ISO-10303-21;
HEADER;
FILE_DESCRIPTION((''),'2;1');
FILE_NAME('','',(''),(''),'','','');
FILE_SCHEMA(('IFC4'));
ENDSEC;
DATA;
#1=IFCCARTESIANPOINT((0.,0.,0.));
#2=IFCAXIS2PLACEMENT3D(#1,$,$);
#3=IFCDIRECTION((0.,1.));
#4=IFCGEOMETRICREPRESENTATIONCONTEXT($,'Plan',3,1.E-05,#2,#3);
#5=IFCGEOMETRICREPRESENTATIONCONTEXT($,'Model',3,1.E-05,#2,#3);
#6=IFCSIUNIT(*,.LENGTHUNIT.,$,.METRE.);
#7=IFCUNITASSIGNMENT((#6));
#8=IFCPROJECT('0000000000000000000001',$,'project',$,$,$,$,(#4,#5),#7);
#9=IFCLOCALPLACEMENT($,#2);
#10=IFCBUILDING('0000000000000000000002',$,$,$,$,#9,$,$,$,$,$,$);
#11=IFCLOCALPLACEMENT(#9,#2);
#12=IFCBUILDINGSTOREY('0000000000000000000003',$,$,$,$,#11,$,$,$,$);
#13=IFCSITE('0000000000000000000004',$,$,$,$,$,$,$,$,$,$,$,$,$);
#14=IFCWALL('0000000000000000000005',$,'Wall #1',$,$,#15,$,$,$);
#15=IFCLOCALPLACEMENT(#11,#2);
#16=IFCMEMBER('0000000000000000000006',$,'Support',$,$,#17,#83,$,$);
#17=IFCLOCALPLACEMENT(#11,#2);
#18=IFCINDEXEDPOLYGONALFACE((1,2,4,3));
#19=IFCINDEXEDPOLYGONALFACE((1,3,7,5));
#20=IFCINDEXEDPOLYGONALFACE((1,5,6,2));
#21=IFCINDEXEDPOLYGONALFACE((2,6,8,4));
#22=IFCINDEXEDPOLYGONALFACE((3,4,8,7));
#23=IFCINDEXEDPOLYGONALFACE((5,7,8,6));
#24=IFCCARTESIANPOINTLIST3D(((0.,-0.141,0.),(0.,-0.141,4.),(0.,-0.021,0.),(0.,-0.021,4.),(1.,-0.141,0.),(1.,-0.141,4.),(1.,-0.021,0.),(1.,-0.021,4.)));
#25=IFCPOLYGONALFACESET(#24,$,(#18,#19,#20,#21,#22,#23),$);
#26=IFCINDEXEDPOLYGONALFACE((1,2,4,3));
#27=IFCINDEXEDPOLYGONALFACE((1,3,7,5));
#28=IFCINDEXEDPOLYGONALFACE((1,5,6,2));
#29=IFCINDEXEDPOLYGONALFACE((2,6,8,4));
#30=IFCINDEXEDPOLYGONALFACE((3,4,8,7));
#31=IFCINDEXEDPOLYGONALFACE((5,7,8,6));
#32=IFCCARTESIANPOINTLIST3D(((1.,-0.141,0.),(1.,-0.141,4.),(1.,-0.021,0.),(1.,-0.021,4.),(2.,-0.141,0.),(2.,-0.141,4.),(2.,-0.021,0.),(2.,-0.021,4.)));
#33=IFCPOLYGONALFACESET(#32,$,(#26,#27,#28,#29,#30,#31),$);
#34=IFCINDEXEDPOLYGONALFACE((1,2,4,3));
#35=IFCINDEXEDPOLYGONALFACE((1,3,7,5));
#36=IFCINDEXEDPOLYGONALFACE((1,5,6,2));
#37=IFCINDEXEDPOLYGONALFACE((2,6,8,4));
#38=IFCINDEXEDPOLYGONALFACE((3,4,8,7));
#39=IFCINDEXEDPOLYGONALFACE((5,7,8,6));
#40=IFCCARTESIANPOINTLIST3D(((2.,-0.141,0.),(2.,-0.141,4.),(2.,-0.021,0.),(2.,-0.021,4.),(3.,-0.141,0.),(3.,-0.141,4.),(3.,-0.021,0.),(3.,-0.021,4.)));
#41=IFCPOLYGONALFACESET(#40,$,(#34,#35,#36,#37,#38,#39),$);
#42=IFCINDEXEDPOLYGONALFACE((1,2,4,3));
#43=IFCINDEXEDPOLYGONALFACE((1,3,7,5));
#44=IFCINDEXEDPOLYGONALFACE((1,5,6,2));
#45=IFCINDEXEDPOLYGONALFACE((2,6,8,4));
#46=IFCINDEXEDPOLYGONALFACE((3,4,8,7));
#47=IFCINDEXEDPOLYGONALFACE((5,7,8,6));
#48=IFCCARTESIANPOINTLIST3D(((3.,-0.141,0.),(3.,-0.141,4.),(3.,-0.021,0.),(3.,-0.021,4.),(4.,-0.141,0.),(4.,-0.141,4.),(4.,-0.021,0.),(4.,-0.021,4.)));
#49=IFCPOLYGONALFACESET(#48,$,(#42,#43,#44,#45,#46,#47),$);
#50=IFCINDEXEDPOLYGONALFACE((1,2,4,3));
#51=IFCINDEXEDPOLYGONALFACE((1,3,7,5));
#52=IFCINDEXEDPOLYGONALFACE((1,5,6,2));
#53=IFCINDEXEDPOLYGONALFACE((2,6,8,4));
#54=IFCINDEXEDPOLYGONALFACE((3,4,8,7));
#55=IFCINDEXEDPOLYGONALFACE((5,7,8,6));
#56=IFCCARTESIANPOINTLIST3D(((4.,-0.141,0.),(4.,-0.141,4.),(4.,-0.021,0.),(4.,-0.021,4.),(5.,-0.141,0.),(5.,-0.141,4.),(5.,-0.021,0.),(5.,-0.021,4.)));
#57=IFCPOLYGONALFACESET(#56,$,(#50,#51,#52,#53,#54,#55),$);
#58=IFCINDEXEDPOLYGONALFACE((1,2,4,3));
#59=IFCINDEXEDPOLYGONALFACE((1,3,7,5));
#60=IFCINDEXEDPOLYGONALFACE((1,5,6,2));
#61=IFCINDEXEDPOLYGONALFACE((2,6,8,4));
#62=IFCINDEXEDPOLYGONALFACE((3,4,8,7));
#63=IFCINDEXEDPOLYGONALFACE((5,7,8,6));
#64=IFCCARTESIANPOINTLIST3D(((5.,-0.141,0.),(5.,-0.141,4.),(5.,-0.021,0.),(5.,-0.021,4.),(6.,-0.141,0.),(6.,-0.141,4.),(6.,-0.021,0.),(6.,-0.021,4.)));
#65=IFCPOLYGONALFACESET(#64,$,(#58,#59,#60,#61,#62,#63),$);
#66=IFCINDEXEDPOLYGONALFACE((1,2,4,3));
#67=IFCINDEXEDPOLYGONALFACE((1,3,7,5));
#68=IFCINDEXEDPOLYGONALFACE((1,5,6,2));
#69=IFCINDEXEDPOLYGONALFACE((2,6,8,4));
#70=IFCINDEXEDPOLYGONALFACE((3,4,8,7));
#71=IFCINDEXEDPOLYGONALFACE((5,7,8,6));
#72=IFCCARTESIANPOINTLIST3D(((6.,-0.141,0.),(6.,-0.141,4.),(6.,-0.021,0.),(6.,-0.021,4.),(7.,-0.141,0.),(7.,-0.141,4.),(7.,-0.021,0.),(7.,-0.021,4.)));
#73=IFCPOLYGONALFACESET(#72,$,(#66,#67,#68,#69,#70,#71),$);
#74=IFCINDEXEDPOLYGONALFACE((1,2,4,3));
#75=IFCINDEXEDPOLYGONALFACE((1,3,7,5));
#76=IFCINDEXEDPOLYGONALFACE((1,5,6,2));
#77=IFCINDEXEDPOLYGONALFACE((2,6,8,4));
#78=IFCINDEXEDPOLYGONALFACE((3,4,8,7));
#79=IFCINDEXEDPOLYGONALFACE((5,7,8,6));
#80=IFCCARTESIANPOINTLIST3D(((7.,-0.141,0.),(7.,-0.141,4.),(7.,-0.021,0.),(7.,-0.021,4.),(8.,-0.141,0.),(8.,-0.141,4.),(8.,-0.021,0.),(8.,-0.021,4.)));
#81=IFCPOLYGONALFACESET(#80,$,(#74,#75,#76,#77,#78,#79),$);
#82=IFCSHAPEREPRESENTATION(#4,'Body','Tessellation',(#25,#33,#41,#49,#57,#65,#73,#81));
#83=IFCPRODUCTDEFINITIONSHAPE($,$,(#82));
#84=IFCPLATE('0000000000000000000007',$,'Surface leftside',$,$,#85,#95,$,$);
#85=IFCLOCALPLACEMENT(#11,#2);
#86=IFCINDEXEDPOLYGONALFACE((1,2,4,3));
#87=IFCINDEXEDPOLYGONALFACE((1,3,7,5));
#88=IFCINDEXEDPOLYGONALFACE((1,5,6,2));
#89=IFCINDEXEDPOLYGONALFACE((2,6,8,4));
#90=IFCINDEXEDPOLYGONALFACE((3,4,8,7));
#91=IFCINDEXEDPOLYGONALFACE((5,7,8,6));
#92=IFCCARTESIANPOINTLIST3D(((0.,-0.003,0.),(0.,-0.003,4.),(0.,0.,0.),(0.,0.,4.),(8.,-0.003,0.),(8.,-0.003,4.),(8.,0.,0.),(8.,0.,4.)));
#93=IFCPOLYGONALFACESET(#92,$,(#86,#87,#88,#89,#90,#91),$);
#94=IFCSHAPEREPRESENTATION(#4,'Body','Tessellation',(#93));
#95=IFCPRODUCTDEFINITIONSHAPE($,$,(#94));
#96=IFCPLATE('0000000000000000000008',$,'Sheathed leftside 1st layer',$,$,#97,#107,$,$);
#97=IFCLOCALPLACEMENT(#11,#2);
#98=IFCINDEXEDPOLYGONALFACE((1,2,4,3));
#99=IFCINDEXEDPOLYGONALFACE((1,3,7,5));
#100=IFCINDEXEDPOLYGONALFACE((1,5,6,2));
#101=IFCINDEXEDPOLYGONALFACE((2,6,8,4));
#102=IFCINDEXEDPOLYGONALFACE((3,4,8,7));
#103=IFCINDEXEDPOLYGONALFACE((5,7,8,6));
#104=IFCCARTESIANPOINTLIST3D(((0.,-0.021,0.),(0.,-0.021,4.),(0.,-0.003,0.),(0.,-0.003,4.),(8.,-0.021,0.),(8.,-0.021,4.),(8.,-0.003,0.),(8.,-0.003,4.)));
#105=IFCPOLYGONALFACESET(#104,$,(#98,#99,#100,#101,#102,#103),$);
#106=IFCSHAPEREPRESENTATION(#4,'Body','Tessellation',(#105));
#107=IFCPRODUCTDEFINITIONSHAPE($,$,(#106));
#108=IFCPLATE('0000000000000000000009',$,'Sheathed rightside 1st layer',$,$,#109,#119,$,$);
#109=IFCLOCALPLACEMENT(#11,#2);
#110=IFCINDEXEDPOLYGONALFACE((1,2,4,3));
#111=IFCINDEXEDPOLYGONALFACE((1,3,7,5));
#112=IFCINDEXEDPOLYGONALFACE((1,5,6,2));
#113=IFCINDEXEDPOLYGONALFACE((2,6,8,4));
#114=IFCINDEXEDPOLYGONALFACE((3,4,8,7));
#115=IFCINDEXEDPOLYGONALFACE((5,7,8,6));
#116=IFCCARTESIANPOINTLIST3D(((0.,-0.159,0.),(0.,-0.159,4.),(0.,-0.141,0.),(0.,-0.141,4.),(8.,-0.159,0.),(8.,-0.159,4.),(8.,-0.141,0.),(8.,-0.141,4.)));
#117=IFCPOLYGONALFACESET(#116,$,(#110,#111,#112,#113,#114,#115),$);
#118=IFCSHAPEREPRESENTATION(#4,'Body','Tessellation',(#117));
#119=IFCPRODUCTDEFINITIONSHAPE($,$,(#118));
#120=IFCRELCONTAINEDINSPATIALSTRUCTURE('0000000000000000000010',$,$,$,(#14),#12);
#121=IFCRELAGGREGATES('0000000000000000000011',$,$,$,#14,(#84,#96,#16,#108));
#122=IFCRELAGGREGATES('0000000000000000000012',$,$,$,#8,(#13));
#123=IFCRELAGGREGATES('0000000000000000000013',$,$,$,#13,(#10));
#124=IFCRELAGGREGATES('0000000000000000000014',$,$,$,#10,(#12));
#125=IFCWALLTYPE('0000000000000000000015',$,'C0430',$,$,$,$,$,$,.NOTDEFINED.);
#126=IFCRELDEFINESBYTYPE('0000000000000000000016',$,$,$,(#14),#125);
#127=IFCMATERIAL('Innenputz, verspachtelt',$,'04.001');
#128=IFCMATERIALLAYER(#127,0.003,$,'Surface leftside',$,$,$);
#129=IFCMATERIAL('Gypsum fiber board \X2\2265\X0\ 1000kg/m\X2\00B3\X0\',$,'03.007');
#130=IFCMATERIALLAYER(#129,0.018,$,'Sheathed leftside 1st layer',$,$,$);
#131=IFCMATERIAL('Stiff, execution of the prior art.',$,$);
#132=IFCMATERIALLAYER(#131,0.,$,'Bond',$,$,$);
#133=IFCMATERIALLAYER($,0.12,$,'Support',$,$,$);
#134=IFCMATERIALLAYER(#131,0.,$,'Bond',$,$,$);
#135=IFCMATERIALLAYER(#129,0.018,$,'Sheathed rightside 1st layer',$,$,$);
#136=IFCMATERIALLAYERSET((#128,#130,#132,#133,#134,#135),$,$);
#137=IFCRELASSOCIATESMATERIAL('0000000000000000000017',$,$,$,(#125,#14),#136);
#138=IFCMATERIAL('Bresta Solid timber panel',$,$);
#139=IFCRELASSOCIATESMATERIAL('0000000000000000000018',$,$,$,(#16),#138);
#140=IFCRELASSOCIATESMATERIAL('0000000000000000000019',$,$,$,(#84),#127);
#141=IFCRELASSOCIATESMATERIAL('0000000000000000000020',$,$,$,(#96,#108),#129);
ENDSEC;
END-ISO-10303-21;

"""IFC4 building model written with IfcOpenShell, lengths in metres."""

from ifc_helpers import new_model, si_unit, direction, frame, frame_2d, origin, origin_with_axes, place, context, project, spatial, rectangle, extrude, material, layer, layer_set, type_object, element, aggregate, save


model = new_model("IFC4")

# Units and contexts
plan_context = context("Plan", 3, precision=1e-05, world=origin(), true_north=direction((0.0, 1.0)))
model_context = context("Model", 3, precision=1e-05, world=origin(), true_north=direction((0.0, 1.0)))
ifc_project = project(units=[si_unit("LENGTHUNIT", "METRE")], contexts=[plan_context, model_context])

# Site, building, storey
site = spatial("IfcSite", under=ifc_project)
building_placement = place(None, origin())
building = spatial("IfcBuilding", under=site, at=building_placement)
storey_placement = place(building_placement, origin())
storey = spatial("IfcBuildingStorey", under=building, at=storey_placement)

# Wall, member, plates
ifc_material_1 = material(Name="Innenputz, verspachtelt", Category="04.001")
ifc_layer_1 = layer(ifc_material_1, 0.003, Name="Surface leftside")
ifc_material_2 = material(Name="Gypsum fiber board ≥ 1000kg/m³", Category="03.007")
ifc_layer_2 = layer(ifc_material_2, 0.018, Name="Sheathed leftside 1st layer")
ifc_material_3 = material(Name="Stiff, execution of the prior art.")
ifc_layer_3 = layer(ifc_material_3, 0.0, Name="Bond")
ifc_layer_4 = layer(None, 0.12, Name="Support")
ifc_layer_5 = layer(ifc_material_3, 0.0, Name="Bond")
ifc_layer_6 = layer(ifc_material_2, 0.018, Name="Sheathed rightside 1st layer")
ifc_layer_set = layer_set([ifc_layer_1, ifc_layer_2, ifc_layer_3, ifc_layer_4, ifc_layer_5, ifc_layer_6])
wall_type = type_object("IfcWallType", Name="C0430", PredefinedType="NOTDEFINED", material=ifc_layer_set)
wall_placement = place(None, frame((0.0, 0.0, 0.0), z_axis=(0.0, -1.0, 0.0), x_axis=(1.0, 0.0, 0.0)))
wall = element("IfcWall", 1, at=wall_placement, inside=storey, type_object=wall_type, material=ifc_layer_set, Name="Wall #1")
ifc_material_4 = material(Name="Bresta Solid timber panel")
member_placement = place(wall_placement, origin())
member = element("IfcMember", 2, at=member_placement, material=ifc_material_4, Name="Support", context=plan_context, shape_type="SweptSolid", body=[
    extrude(rectangle(XDim=1.0, YDim=0.12, at=frame_2d((0.5, 0.06), x_axis=(1.0, 0.0))), frame((0.0, 4.0, 0.021), z_axis=(0.0, -1.0, 0.0), x_axis=(1.0, 0.0, 0.0)), (0.0, 0.0, 1.0), 4.0),
    extrude(rectangle(XDim=1.0, YDim=0.12, at=frame_2d((0.5, 0.06), x_axis=(1.0, 0.0))), frame((1.0, 4.0, 0.021), z_axis=(0.0, -1.0, 0.0), x_axis=(1.0, 0.0, 0.0)), (0.0, 0.0, 1.0), 4.0),
    extrude(rectangle(XDim=1.0, YDim=0.12, at=frame_2d((0.5, 0.06), x_axis=(1.0, 0.0))), frame((2.0, 4.0, 0.021), z_axis=(0.0, -1.0, 0.0), x_axis=(1.0, 0.0, 0.0)), (0.0, 0.0, 1.0), 4.0),
    extrude(rectangle(XDim=1.0, YDim=0.12, at=frame_2d((0.5, 0.06), x_axis=(1.0, 0.0))), frame((3.0, 4.0, 0.021), z_axis=(0.0, -1.0, 0.0), x_axis=(1.0, 0.0, 0.0)), (0.0, 0.0, 1.0), 4.0),
    extrude(rectangle(XDim=1.0, YDim=0.12, at=frame_2d((0.5, 0.06), x_axis=(1.0, 0.0))), frame((4.0, 4.0, 0.021), z_axis=(0.0, -1.0, 0.0), x_axis=(1.0, 0.0, 0.0)), (0.0, 0.0, 1.0), 4.0),
    extrude(rectangle(XDim=1.0, YDim=0.12, at=frame_2d((0.5, 0.06), x_axis=(1.0, 0.0))), frame((5.0, 4.0, 0.021), z_axis=(0.0, -1.0, 0.0), x_axis=(1.0, 0.0, 0.0)), (0.0, 0.0, 1.0), 4.0),
    extrude(rectangle(XDim=1.0, YDim=0.12, at=frame_2d((0.5, 0.06), x_axis=(1.0, 0.0))), frame((6.0, 4.0, 0.021), z_axis=(0.0, -1.0, 0.0), x_axis=(1.0, 0.0, 0.0)), (0.0, 0.0, 1.0), 4.0),
    extrude(rectangle(XDim=1.0, YDim=0.12, at=frame_2d((0.5, 0.06), x_axis=(1.0, 0.0))), frame((7.0, 4.0, 0.021), z_axis=(0.0, -1.0, 0.0), x_axis=(1.0, 0.0, 0.0)), (0.0, 0.0, 1.0), 4.0),
])
plate_1_placement = place(wall_placement, origin())
plate_1 = element("IfcPlate", 3, at=plate_1_placement, material=ifc_material_1, Name="Surface leftside", context=plan_context, shape_type="SweptSolid", body=[
    extrude(rectangle(XDim=8.0, YDim=4.0, at=frame_2d((4.0, 2.0), x_axis=(1.0, 0.0))), origin_with_axes(), (0.0, 0.0, 1.0), 0.003),
])
plate_2_placement = place(wall_placement, origin())
plate_2 = element("IfcPlate", 4, at=plate_2_placement, material=ifc_material_2, Name="Sheathed leftside 1st layer", context=plan_context, shape_type="SweptSolid", body=[
    extrude(rectangle(XDim=8.0, YDim=4.0, at=frame_2d((4.0, 2.0), x_axis=(1.0, 0.0))), frame((0.0, 0.0, 0.003), z_axis=(0.0, 0.0, 1.0), x_axis=(1.0, 0.0, 0.0)), (0.0, 0.0, 1.0), 0.018),
])
plate_3_placement = place(wall_placement, origin())
plate_3 = element("IfcPlate", 5, at=plate_3_placement, material=ifc_material_2, Name="Sheathed rightside 1st layer", context=plan_context, shape_type="SweptSolid", body=[
    extrude(rectangle(XDim=8.0, YDim=4.0, at=frame_2d((4.0, 2.0), x_axis=(1.0, 0.0))), frame((0.0, 0.0, 0.141), z_axis=(0.0, 0.0, 1.0), x_axis=(1.0, 0.0, 0.0)), (0.0, 0.0, 1.0), 0.018),
])
aggregate(wall, [plate_1, plate_2, member, plate_3])

save(model, "model.ifc")
